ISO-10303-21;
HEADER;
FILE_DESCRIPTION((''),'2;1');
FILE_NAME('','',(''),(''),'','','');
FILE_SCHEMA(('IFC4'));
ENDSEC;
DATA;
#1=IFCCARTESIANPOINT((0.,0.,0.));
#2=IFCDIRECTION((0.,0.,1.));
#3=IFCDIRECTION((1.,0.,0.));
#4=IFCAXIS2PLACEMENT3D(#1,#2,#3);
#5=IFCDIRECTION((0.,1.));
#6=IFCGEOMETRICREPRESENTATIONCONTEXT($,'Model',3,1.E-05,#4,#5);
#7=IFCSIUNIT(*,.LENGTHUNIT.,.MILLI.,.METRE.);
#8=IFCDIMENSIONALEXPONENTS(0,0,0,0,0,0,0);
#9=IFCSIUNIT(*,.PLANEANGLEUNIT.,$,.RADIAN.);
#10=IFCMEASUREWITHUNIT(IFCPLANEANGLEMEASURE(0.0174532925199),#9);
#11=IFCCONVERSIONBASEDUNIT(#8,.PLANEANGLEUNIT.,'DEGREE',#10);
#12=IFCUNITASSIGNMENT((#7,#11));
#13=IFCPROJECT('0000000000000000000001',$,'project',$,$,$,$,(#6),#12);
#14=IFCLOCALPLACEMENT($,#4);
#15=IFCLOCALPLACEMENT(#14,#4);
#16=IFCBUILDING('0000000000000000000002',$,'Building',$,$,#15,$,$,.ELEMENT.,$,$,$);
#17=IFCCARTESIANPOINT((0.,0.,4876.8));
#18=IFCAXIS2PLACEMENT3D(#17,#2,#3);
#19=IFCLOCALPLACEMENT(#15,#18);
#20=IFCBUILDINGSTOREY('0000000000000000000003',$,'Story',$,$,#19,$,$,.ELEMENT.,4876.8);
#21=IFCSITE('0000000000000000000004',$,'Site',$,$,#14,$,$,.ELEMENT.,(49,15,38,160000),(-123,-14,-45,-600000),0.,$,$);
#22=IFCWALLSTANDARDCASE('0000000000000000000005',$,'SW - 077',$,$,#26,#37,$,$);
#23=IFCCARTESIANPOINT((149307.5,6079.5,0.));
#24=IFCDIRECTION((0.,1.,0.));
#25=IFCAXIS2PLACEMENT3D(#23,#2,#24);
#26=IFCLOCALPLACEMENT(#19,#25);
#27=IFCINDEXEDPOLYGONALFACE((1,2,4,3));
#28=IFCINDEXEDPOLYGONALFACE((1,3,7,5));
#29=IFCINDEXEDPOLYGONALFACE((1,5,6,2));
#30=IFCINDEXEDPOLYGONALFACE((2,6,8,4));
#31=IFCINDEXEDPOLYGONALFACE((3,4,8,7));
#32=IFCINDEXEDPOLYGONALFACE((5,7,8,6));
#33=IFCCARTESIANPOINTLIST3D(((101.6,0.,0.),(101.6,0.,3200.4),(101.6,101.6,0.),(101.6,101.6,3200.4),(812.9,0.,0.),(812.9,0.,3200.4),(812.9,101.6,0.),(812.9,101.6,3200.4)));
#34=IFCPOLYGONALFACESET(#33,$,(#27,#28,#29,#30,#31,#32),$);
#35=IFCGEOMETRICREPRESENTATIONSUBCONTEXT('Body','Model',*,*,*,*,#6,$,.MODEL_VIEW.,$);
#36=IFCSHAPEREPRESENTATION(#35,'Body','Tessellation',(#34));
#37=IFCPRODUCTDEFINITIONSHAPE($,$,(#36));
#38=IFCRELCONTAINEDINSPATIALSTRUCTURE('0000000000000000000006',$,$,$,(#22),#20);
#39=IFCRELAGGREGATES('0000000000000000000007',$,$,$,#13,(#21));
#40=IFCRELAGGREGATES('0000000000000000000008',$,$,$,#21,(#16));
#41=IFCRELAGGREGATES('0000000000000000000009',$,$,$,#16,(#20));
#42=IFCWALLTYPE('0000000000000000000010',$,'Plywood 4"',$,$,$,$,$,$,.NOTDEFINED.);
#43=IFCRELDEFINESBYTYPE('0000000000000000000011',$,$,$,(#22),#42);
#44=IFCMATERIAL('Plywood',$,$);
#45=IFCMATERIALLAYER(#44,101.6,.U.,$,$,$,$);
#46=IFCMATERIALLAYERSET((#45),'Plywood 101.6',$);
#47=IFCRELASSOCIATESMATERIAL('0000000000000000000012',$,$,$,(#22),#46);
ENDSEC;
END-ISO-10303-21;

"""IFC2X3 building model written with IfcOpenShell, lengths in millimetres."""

from ifc_helpers import new_model, entity, si_unit, converted_unit, direction, frame, origin_with_axes, place, context, subcontext, project, spatial, polyline, outline, extrude, material, layer, layer_set, layer_usage, type_object, element, save


model = new_model("IFC2X3")

# Units and contexts
model_context = context("Model", 3, precision=1e-05, world=origin_with_axes(), true_north=direction((0.0, 1.0)))
body_context = subcontext(model_context, "Body", "Model", "MODEL_VIEW")
ifc_project = project(units=[si_unit("LENGTHUNIT", "METRE", prefix="MILLI"), converted_unit("PLANEANGLEUNIT", "DEGREE", entity("IfcPlaneAngleMeasure", 0.0174532925199), si_unit("PLANEANGLEUNIT", "RADIAN"), dimensions=[0, 0, 0, 0, 0, 0, 0])], contexts=[model_context])

# Site, building, storey
site_placement = place(None, origin_with_axes())
site = spatial("IfcSite", under=ifc_project, at=site_placement, Name="Site", CompositionType="ELEMENT", RefLatitude=(49, 15, 38, 160000), RefLongitude=(-123, -14, -45, -600000), RefElevation=0.0)
building_placement = place(site_placement, origin_with_axes())
building = spatial("IfcBuilding", under=site, at=building_placement, Name="Building", CompositionType="ELEMENT")
storey_placement = place(building_placement, frame((0.0, 0.0, 4876.8), z_axis=(0.0, 0.0, 1.0), x_axis=(1.0, 0.0, 0.0)))
storey = spatial("IfcBuildingStorey", under=building, at=storey_placement, Name="Story", CompositionType="ELEMENT", Elevation=4876.8)

# Shared definitions
ifc_material_1 = material(Name="Plywood")

# Shared definitions
ifc_layer_1 = layer(ifc_material_1, 101.6, ventilated="UNKNOWN")
ifc_layer_set_1 = layer_set([ifc_layer_1], Name="Plywood 101.6")
wall_type_1 = type_object("IfcWallType", Name="Plywood 4\"", PredefinedType="NOTDEFINED")

# Wall
ifc_layer_usage_1 = layer_usage(ifc_layer_set_1, "AXIS2", "POSITIVE", 0.0)
wall_1_placement = place(storey_placement, frame((149307.5, 6079.5, 0.0), z_axis=(0.0, 0.0, 1.0), x_axis=(0.0, 1.0, 0.0)))
element("IfcWallStandardCase", 1, at=wall_1_placement, inside=storey, type_object=wall_type_1, material=ifc_layer_usage_1, Name="SW - 077", context=body_context, shape_type="SweptSolid", body=[
    extrude(outline(polyline([(101.6, 0.0), (812.9, 0.0), (812.9, 101.6), (101.6, 101.6), (101.6, 0.0)])), origin_with_axes(), (0.0, 0.0, 1.0), 3200.4),
])

save(model, "model.ifc")
